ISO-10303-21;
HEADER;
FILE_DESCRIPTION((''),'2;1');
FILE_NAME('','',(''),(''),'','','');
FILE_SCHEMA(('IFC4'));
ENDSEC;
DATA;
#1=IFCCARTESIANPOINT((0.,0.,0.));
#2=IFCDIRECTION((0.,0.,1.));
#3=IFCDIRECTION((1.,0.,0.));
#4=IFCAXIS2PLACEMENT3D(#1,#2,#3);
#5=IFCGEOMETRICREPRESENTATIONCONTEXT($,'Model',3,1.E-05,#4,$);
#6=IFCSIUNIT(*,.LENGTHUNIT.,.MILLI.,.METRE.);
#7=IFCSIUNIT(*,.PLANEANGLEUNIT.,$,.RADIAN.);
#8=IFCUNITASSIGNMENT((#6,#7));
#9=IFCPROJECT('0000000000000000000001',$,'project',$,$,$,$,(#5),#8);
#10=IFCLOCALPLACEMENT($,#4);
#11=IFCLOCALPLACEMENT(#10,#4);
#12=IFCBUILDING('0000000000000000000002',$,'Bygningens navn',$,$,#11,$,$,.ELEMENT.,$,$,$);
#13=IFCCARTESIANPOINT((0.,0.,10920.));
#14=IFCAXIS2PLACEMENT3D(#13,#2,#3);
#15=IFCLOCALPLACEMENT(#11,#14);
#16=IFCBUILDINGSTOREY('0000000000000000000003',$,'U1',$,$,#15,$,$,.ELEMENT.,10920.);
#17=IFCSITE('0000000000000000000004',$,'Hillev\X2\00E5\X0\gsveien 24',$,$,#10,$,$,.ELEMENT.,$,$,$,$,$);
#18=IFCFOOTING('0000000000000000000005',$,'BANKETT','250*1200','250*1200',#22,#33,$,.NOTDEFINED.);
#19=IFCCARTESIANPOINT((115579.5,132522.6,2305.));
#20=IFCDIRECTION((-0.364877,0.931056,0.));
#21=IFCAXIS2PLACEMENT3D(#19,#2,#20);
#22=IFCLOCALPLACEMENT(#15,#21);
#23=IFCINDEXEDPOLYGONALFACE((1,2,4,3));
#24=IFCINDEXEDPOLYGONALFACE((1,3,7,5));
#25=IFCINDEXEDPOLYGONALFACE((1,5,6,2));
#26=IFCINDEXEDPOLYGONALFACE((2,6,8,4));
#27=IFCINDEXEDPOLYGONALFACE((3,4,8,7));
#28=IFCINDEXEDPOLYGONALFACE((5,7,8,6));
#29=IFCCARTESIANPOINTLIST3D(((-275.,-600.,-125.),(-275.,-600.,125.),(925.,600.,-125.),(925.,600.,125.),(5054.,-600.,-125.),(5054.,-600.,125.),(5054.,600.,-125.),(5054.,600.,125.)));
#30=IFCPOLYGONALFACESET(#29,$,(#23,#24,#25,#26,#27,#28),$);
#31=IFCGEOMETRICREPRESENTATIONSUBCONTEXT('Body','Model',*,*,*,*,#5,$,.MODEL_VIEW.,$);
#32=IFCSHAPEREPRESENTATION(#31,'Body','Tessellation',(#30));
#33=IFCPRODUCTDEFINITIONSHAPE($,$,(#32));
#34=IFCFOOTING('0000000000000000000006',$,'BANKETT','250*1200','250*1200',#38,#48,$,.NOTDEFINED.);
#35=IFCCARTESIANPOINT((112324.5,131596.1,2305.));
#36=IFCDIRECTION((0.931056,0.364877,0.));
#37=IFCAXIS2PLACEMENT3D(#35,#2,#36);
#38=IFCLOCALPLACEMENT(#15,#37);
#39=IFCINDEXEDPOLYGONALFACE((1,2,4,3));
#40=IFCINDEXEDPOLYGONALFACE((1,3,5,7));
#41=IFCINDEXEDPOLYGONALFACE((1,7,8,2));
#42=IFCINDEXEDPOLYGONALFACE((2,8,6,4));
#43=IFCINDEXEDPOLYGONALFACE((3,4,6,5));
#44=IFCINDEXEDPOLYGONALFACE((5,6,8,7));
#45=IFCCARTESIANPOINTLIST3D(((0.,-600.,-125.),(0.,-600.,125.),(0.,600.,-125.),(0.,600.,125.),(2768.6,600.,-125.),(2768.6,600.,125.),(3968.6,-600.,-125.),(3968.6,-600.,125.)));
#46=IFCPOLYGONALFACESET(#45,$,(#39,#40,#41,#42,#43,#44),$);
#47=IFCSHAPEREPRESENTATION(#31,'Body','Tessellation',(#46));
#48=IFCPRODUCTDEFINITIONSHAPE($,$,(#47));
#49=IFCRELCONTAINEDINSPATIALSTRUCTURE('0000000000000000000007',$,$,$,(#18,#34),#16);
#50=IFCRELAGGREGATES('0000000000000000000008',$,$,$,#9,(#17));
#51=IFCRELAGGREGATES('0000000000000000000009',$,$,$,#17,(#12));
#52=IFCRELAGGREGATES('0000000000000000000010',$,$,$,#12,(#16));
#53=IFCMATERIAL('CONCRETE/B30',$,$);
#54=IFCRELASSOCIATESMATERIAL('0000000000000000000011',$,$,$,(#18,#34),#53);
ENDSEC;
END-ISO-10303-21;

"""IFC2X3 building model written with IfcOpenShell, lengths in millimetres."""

from ifc_helpers import new_model, si_unit, frame, frame_2d, origin_with_axes, place, context, subcontext, project, spatial, rectangle, extrude, clip, halfspace, material, element, save


model = new_model("IFC2X3")

# Units and contexts
model_context = context("Model", 3, precision=1e-05, world=origin_with_axes())
body_context = subcontext(model_context, "Body", "Model", "MODEL_VIEW")
ifc_project = project(units=[si_unit("LENGTHUNIT", "METRE", prefix="MILLI"), si_unit("PLANEANGLEUNIT", "RADIAN")], contexts=[model_context])

# Site, building, storey
site_placement = place(None, origin_with_axes())
site = spatial("IfcSite", under=ifc_project, at=site_placement, Name="Hillevågsveien 24", CompositionType="ELEMENT")
building_placement = place(site_placement, origin_with_axes())
building = spatial("IfcBuilding", under=site, at=building_placement, Name="Bygningens navn", CompositionType="ELEMENT")
storey_placement = place(building_placement, frame((0.0, 0.0, 10920.0), z_axis=(0.0, 0.0, 1.0), x_axis=(1.0, 0.0, 0.0)))
storey = spatial("IfcBuildingStorey", under=building, at=storey_placement, Name="U1", CompositionType="ELEMENT", Elevation=10920.0)

# Footings
ifc_material_1 = material(Name="CONCRETE/B30")
footing_1_placement = place(storey_placement, frame((115579.5, 132522.6, 2305.0), z_axis=(0.0, 0.0, 1.0), x_axis=(-0.364877, 0.931056, 0.0)))
element("IfcFooting", 1, at=footing_1_placement, inside=storey, material=ifc_material_1, Name="BANKETT", Description="250*1200", ObjectType="250*1200", PredefinedType="NOTDEFINED", context=body_context, shape_type="Clipping", body=[
    clip(extrude(rectangle(XDim=1200.0, YDim=250.0, at=frame_2d((0.0, 0.0), x_axis=(1.0, 0.0))), frame((5054.0, 0.0, 0.0), z_axis=(-1.0, 0.0, 0.0), x_axis=(0.0, -1.0, 0.0)), (0.0, 0.0, 1.0), 5746.7), halfspace(frame((925.0, 600.0, 0.0), z_axis=(-0.707107, 0.707107, 0.0), x_axis=(0.0, 0.0, 1.0)), False)),
])
footing_2_placement = place(storey_placement, frame((112324.5, 131596.1, 2305.0), z_axis=(0.0, 0.0, 1.0), x_axis=(0.931056, 0.364877, 0.0)))
element("IfcFooting", 2, at=footing_2_placement, inside=storey, material=ifc_material_1, Name="BANKETT", Description="250*1200", ObjectType="250*1200", PredefinedType="NOTDEFINED", context=body_context, shape_type="Clipping", body=[
    clip(extrude(rectangle(XDim=1200.0, YDim=250.0, at=frame_2d((0.0, 0.0), x_axis=(1.0, 0.0))), frame((4636.8, 0.0, 0.0), z_axis=(-1.0, 0.0, 0.0), x_axis=(0.0, -1.0, 0.0)), (0.0, 0.0, 1.0), 4636.8), halfspace(frame((2768.6, 600.0, 0.0), z_axis=(-0.707107, -0.707106, 0.0), x_axis=(0.0, 0.0, 1.0)), True)),
])

save(model, "model.ifc")
